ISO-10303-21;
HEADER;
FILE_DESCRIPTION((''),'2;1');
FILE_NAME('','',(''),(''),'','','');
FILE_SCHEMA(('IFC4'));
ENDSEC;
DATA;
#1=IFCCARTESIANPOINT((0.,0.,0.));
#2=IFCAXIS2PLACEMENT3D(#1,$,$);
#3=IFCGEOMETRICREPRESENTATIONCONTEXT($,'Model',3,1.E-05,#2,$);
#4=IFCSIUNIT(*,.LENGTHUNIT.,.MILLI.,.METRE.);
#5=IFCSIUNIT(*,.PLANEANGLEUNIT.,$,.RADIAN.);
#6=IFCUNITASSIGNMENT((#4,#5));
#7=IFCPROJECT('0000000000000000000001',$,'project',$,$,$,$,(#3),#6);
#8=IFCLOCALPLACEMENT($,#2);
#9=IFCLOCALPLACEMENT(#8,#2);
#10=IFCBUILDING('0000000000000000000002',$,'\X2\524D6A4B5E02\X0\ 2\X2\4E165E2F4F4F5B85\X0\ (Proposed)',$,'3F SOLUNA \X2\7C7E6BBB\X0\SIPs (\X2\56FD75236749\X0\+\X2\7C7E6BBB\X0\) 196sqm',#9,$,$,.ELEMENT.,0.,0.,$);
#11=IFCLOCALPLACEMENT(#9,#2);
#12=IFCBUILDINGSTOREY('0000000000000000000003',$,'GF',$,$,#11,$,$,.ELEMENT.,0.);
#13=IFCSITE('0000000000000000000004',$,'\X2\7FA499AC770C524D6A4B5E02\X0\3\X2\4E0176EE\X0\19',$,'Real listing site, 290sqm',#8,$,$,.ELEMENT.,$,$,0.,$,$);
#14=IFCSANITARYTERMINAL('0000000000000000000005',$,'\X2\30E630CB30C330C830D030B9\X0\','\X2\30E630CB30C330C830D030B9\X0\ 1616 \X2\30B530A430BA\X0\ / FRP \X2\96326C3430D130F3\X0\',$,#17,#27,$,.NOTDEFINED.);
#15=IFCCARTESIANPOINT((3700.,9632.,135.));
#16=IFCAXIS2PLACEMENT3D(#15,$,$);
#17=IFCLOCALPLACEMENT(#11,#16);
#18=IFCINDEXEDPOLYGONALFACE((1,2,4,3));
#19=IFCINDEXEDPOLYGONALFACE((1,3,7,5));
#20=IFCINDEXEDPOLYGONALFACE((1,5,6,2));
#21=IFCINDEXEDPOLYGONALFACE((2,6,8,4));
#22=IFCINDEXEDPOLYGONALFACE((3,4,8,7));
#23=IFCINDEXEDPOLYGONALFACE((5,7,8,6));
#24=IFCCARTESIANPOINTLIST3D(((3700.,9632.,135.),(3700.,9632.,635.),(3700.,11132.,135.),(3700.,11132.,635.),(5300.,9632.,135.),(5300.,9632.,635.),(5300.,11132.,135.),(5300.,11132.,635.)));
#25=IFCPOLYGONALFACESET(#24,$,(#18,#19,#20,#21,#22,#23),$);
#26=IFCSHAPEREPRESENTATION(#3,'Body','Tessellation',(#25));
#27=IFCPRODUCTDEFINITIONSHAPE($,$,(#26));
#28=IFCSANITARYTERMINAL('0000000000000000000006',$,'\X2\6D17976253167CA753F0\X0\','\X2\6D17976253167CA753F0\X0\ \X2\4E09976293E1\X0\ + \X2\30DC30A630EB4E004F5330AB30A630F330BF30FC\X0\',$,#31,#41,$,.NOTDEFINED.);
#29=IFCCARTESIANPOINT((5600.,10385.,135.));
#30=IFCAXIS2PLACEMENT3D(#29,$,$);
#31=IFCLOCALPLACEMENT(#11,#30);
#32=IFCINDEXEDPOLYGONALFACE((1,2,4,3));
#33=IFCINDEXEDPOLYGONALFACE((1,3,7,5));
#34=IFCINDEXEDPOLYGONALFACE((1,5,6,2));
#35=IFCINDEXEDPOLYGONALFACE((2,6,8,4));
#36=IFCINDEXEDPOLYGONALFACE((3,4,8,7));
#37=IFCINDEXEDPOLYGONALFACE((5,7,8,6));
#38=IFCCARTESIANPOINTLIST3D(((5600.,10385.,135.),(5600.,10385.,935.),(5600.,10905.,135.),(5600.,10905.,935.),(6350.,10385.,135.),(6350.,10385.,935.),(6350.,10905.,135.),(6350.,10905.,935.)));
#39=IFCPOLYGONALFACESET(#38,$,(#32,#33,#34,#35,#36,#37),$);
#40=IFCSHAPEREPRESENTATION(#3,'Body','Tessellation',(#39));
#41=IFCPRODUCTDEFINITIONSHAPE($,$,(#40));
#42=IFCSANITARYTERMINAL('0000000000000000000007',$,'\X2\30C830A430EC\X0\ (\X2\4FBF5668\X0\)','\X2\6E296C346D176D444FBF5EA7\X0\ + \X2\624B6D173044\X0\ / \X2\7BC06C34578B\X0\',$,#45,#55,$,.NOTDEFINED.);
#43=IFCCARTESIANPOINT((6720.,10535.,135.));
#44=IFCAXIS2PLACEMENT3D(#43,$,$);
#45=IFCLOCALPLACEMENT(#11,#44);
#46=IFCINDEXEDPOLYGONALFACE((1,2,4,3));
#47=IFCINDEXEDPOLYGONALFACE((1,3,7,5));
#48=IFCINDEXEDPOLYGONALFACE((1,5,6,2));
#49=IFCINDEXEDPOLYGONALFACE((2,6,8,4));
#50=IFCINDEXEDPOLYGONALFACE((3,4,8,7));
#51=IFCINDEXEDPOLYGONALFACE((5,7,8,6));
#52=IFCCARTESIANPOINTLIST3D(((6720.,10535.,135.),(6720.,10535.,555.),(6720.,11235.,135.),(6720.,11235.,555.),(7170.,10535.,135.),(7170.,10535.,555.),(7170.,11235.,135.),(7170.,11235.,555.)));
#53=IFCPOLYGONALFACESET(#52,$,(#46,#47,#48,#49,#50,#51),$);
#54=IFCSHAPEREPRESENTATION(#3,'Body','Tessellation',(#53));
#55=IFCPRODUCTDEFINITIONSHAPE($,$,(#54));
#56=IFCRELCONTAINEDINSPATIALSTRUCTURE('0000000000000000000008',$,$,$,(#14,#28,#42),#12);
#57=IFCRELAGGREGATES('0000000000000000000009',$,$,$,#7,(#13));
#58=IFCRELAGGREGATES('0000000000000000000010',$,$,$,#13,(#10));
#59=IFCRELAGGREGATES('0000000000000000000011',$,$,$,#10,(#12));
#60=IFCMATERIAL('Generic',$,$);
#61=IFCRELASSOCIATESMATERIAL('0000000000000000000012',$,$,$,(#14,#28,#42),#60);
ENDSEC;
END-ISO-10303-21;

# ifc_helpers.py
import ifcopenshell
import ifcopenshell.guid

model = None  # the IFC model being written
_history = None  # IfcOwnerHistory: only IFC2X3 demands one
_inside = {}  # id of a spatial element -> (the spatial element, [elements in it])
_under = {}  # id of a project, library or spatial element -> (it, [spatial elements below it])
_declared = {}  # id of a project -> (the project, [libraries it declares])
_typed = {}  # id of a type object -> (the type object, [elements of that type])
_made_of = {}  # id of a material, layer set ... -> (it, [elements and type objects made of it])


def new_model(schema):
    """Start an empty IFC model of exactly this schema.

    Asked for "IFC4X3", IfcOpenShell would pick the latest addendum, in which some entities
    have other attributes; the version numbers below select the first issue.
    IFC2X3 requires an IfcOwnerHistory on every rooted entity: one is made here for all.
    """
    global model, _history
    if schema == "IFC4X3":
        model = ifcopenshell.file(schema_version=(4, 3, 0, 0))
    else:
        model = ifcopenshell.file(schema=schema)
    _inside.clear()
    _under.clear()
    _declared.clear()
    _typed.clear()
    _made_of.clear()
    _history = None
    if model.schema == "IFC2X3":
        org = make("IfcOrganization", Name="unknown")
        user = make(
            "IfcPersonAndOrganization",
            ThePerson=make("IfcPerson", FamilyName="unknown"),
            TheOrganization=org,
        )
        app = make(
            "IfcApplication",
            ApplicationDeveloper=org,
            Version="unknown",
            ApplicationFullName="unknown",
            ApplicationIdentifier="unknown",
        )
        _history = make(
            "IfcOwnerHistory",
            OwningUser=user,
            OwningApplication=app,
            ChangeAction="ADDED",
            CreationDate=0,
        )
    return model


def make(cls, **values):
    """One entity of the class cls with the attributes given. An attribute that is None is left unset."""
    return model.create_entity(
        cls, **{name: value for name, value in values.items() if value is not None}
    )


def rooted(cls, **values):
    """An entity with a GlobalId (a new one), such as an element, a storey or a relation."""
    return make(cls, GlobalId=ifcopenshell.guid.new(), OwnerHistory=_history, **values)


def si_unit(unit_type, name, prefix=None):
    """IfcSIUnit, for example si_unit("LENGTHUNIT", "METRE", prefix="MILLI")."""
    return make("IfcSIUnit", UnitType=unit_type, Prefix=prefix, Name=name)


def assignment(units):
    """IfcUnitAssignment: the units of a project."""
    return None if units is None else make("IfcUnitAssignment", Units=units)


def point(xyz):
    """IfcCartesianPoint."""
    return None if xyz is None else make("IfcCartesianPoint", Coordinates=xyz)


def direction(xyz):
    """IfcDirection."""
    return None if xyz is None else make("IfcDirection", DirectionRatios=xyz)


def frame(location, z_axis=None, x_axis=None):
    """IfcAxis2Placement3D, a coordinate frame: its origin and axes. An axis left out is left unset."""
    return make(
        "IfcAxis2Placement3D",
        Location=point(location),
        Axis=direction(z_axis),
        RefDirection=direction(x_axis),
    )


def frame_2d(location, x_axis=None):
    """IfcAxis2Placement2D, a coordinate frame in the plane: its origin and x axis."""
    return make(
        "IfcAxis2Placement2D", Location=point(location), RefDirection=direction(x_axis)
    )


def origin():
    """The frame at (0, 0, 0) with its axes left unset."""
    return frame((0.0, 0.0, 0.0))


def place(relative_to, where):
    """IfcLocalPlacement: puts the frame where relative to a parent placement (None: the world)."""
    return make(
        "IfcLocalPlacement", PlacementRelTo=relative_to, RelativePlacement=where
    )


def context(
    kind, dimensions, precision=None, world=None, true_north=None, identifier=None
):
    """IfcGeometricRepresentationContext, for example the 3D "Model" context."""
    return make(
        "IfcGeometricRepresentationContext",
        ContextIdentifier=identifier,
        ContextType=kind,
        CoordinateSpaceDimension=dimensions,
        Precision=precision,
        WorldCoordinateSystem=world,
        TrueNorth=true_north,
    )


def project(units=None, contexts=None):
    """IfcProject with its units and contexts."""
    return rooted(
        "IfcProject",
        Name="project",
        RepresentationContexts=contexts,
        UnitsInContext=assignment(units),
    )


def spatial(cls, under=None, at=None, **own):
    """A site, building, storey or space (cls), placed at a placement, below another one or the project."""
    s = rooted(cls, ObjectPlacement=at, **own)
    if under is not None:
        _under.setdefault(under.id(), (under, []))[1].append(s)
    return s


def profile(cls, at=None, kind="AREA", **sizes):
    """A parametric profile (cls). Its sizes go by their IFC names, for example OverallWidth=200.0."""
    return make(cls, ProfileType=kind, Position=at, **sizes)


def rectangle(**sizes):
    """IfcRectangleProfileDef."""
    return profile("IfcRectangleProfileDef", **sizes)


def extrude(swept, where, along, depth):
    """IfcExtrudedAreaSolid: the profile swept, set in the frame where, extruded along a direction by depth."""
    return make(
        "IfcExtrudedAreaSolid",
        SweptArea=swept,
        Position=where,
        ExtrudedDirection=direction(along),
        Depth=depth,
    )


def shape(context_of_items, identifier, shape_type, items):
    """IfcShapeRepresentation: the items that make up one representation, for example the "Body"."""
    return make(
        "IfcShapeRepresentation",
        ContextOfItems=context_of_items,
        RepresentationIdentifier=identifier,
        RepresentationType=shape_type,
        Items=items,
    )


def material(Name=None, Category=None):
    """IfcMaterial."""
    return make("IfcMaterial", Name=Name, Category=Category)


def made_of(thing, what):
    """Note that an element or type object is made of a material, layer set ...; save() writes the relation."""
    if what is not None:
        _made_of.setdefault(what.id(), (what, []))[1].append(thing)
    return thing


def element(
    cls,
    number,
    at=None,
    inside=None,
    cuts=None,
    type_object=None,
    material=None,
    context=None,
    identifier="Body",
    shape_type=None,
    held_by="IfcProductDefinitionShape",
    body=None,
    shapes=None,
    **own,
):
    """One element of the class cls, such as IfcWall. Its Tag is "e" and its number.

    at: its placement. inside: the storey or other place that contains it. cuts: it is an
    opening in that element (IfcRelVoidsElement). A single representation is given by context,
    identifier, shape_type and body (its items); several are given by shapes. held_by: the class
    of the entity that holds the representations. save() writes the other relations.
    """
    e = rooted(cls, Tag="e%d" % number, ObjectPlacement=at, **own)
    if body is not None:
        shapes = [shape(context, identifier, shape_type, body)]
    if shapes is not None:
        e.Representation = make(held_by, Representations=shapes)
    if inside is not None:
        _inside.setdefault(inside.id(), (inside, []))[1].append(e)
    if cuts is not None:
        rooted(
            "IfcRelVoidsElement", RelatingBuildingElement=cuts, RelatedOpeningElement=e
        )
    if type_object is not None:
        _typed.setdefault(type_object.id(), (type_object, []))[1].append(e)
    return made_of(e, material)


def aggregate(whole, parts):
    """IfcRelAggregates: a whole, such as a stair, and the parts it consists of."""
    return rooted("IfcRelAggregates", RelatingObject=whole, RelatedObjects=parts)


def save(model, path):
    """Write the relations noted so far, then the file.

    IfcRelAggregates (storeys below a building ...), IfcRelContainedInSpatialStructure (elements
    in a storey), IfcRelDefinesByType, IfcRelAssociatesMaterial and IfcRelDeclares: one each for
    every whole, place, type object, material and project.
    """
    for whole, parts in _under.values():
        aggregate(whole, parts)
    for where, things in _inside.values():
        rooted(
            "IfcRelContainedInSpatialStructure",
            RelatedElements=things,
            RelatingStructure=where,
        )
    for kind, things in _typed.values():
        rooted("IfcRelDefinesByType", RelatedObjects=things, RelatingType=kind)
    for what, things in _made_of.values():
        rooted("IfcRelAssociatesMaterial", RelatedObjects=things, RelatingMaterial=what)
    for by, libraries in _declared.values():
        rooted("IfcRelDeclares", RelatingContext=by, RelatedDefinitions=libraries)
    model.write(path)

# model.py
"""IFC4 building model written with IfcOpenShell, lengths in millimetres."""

from ifc_helpers import new_model, si_unit, frame, frame_2d, origin, place, context, project, spatial, rectangle, extrude, material, element, save


model = new_model("IFC4")

# Units and contexts
model_context = context("Model", 3, precision=1e-05, world=origin())
ifc_project = project(units=[si_unit("LENGTHUNIT", "METRE", prefix="MILLI"), si_unit("PLANEANGLEUNIT", "RADIAN")], contexts=[model_context])

# Site, building, storey
site_placement = place(None, origin())
site = spatial("IfcSite", under=ifc_project, at=site_placement, Name="群馬県前橋市3丁目19", ObjectType="Real listing site, 290sqm", CompositionType="ELEMENT", RefElevation=0.0)
building_placement = place(site_placement, origin())
building = spatial("IfcBuilding", under=site, at=building_placement, Name="前橋市 2世帯住宅 (Proposed)", ObjectType="3F SOLUNA 籾殻SIPs (国産杉+籾殻) 196sqm", CompositionType="ELEMENT", ElevationOfRefHeight=0.0, ElevationOfTerrain=0.0)
storey_placement = place(building_placement, origin())
storey = spatial("IfcBuildingStorey", under=building, at=storey_placement, Name="GF", CompositionType="ELEMENT", Elevation=0.0)

# Shared definitions
ifc_material_1 = material(Name="Generic")

# Sanitary terminals
sanitary_terminal_1_placement = place(storey_placement, frame((3700.0, 9632.0, 135.0)))
element("IfcSanitaryTerminal", 1, at=sanitary_terminal_1_placement, inside=storey, material=ifc_material_1, Name="ユニットバス", Description="ユニットバス 1616 サイズ / FRP 防水パン", PredefinedType="NOTDEFINED", context=model_context, shape_type="SweptSolid", body=[
    extrude(rectangle(XDim=1600.0, YDim=1500.0, at=frame_2d((800.0, 750.0))), frame((3700.0, 9632.0, 135.0)), (0.0, 0.0, 1.0), 500.0),
])
sanitary_terminal_2_placement = place(storey_placement, frame((5600.0, 10385.0, 135.0)))
element("IfcSanitaryTerminal", 2, at=sanitary_terminal_2_placement, inside=storey, material=ifc_material_1, Name="洗面化粧台", Description="洗面化粧台 三面鏡 + ボウル一体カウンター", PredefinedType="NOTDEFINED", context=model_context, shape_type="SweptSolid", body=[
    extrude(rectangle(XDim=750.0, YDim=520.0, at=frame_2d((375.0, 260.0))), frame((5600.0, 10385.0, 135.0)), (0.0, 0.0, 1.0), 800.0),
])
sanitary_terminal_3_placement = place(storey_placement, frame((6720.0, 10535.0, 135.0)))
element("IfcSanitaryTerminal", 3, at=sanitary_terminal_3_placement, inside=storey, material=ifc_material_1, Name="トイレ (便器)", Description="温水洗浄便座 + 手洗い / 節水型", PredefinedType="NOTDEFINED", context=model_context, shape_type="SweptSolid", body=[
    extrude(rectangle(XDim=450.0, YDim=700.0, at=frame_2d((225.0, 350.0))), frame((6720.0, 10535.0, 135.0)), (0.0, 0.0, 1.0), 420.0),
])

save(model, "model.ifc")
